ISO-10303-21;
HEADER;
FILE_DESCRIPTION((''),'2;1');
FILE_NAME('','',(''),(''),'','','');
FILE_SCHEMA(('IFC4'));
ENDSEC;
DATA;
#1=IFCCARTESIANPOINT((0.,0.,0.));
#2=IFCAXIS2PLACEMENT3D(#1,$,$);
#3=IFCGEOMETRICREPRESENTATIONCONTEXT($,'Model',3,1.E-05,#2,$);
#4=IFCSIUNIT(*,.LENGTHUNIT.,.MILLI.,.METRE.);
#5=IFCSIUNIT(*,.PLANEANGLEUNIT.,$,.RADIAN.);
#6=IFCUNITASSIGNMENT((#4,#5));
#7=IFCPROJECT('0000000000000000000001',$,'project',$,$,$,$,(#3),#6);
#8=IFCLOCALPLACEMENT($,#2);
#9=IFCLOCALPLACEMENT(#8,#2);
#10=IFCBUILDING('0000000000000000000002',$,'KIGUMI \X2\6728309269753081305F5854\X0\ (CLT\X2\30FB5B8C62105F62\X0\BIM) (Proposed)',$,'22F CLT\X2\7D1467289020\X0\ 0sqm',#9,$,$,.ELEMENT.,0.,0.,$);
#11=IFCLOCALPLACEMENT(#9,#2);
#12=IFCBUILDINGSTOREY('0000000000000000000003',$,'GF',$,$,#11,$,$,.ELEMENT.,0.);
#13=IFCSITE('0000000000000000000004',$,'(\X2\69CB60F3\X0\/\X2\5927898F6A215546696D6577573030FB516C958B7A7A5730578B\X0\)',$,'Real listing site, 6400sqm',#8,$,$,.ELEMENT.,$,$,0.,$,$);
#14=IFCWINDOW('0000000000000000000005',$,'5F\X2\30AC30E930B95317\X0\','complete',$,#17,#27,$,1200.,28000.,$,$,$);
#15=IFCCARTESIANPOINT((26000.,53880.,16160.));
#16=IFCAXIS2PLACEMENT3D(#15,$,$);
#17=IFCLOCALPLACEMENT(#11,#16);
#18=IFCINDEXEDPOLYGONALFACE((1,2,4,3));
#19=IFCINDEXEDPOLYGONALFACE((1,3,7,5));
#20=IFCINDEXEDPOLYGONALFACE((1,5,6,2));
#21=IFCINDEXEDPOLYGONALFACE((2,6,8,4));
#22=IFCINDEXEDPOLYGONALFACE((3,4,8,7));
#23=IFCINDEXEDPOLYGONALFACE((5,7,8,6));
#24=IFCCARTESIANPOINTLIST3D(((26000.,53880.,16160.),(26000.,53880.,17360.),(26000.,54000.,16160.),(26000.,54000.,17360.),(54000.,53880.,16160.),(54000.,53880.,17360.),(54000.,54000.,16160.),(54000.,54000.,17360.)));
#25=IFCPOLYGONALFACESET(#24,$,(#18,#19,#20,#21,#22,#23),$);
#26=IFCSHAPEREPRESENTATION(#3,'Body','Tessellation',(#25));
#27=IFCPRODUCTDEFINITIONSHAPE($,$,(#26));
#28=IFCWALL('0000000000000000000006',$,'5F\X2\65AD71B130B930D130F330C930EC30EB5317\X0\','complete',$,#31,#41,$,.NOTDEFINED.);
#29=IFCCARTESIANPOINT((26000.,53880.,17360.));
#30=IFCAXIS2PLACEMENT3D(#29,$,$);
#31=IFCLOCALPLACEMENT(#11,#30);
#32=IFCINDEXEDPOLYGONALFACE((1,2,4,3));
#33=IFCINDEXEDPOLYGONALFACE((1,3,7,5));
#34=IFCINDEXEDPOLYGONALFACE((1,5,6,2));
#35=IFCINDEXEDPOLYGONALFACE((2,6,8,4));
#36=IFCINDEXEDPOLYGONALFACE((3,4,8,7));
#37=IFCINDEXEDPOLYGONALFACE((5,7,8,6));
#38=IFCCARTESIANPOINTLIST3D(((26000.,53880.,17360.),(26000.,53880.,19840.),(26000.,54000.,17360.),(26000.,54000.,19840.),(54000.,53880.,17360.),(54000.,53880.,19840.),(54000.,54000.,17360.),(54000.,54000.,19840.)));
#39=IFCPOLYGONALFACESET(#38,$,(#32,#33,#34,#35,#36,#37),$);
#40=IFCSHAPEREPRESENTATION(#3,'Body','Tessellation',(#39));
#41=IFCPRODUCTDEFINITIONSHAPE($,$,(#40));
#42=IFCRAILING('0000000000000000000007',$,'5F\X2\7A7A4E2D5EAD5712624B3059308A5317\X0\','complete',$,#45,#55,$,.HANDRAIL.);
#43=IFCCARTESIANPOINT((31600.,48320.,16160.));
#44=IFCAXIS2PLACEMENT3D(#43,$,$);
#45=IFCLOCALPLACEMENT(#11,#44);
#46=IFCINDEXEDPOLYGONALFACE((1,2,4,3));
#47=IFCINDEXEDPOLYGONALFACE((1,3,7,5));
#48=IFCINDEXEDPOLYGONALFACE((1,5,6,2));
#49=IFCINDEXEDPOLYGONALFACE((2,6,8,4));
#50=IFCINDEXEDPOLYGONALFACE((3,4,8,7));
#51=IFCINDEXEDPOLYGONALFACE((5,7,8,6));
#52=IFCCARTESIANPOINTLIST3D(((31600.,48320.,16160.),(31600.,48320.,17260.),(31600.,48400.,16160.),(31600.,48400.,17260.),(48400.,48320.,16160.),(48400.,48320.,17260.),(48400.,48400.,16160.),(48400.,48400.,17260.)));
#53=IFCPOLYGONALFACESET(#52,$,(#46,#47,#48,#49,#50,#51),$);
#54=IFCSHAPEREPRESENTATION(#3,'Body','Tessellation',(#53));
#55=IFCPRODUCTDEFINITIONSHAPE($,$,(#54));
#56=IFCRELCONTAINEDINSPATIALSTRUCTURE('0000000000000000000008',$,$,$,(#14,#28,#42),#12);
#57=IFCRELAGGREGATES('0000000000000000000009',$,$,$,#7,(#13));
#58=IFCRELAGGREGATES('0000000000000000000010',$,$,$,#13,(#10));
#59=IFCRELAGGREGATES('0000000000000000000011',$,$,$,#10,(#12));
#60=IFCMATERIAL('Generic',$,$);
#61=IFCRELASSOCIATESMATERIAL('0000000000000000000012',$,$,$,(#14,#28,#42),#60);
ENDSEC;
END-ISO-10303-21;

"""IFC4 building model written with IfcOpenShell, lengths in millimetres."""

from ifc_helpers import new_model, si_unit, frame, frame_2d, origin, place, context, project, spatial, rectangle, extrude, material, element, save


model = new_model("IFC4")

# Units and contexts
model_context = context("Model", 3, precision=1e-05, world=origin())
ifc_project = project(units=[si_unit("LENGTHUNIT", "METRE", prefix="MILLI"), si_unit("PLANEANGLEUNIT", "RADIAN")], contexts=[model_context])

# Site, building, storey
site_placement = place(None, origin())
site = spatial("IfcSite", under=ifc_project, at=site_placement, Name="(構想/大規模商業敷地・公開空地型)", ObjectType="Real listing site, 6400sqm", CompositionType="ELEMENT", RefElevation=0.0)
building_placement = place(site_placement, origin())
building = spatial("IfcBuilding", under=site, at=building_placement, Name="KIGUMI 木を極めた塔 (CLT・完成形BIM) (Proposed)", ObjectType="22F CLT純木造 0sqm", CompositionType="ELEMENT", ElevationOfRefHeight=0.0, ElevationOfTerrain=0.0)
storey_placement = place(building_placement, origin())
storey = spatial("IfcBuildingStorey", under=building, at=storey_placement, Name="GF", CompositionType="ELEMENT", Elevation=0.0)

# Shared definitions
ifc_material = material(Name="Generic")

# Window
window_1_placement = place(storey_placement, frame((26000.0, 53880.0, 16160.0)))
element("IfcWindow", 1, at=window_1_placement, inside=storey, material=ifc_material, Name="5Fガラス北", Description="complete", OverallHeight=1200.0, OverallWidth=28000.0, context=model_context, shape_type="SweptSolid", body=[
    extrude(rectangle(XDim=28000.0, YDim=120.0, at=frame_2d((14000.0, 60.0))), frame((26000.0, 53880.0, 16160.0)), (0.0, 0.0, 1.0), 1200.0),
])

# Wall
wall_1_placement = place(storey_placement, frame((26000.0, 53880.0, 17360.0)))
element("IfcWall", 2, at=wall_1_placement, inside=storey, material=ifc_material, Name="5F断熱スパンドレル北", Description="complete", PredefinedType="NOTDEFINED", context=model_context, shape_type="SweptSolid", body=[
    extrude(rectangle(XDim=28000.0, YDim=120.0, at=frame_2d((14000.0, 60.0))), frame((26000.0, 53880.0, 17360.0)), (0.0, 0.0, 1.0), 2480.0),
])

# Railing
railing_placement = place(storey_placement, frame((31600.0, 48320.0, 16160.0)))
element("IfcRailing", 3, at=railing_placement, inside=storey, material=ifc_material, Name="5F空中庭園手すり北", Description="complete", PredefinedType="HANDRAIL", context=model_context, shape_type="SweptSolid", body=[
    extrude(rectangle(XDim=16800.0, YDim=80.0, at=frame_2d((8400.0, 40.0))), frame((31600.0, 48320.0, 16160.0)), (0.0, 0.0, 1.0), 1100.0),
])

save(model, "model.ifc")
